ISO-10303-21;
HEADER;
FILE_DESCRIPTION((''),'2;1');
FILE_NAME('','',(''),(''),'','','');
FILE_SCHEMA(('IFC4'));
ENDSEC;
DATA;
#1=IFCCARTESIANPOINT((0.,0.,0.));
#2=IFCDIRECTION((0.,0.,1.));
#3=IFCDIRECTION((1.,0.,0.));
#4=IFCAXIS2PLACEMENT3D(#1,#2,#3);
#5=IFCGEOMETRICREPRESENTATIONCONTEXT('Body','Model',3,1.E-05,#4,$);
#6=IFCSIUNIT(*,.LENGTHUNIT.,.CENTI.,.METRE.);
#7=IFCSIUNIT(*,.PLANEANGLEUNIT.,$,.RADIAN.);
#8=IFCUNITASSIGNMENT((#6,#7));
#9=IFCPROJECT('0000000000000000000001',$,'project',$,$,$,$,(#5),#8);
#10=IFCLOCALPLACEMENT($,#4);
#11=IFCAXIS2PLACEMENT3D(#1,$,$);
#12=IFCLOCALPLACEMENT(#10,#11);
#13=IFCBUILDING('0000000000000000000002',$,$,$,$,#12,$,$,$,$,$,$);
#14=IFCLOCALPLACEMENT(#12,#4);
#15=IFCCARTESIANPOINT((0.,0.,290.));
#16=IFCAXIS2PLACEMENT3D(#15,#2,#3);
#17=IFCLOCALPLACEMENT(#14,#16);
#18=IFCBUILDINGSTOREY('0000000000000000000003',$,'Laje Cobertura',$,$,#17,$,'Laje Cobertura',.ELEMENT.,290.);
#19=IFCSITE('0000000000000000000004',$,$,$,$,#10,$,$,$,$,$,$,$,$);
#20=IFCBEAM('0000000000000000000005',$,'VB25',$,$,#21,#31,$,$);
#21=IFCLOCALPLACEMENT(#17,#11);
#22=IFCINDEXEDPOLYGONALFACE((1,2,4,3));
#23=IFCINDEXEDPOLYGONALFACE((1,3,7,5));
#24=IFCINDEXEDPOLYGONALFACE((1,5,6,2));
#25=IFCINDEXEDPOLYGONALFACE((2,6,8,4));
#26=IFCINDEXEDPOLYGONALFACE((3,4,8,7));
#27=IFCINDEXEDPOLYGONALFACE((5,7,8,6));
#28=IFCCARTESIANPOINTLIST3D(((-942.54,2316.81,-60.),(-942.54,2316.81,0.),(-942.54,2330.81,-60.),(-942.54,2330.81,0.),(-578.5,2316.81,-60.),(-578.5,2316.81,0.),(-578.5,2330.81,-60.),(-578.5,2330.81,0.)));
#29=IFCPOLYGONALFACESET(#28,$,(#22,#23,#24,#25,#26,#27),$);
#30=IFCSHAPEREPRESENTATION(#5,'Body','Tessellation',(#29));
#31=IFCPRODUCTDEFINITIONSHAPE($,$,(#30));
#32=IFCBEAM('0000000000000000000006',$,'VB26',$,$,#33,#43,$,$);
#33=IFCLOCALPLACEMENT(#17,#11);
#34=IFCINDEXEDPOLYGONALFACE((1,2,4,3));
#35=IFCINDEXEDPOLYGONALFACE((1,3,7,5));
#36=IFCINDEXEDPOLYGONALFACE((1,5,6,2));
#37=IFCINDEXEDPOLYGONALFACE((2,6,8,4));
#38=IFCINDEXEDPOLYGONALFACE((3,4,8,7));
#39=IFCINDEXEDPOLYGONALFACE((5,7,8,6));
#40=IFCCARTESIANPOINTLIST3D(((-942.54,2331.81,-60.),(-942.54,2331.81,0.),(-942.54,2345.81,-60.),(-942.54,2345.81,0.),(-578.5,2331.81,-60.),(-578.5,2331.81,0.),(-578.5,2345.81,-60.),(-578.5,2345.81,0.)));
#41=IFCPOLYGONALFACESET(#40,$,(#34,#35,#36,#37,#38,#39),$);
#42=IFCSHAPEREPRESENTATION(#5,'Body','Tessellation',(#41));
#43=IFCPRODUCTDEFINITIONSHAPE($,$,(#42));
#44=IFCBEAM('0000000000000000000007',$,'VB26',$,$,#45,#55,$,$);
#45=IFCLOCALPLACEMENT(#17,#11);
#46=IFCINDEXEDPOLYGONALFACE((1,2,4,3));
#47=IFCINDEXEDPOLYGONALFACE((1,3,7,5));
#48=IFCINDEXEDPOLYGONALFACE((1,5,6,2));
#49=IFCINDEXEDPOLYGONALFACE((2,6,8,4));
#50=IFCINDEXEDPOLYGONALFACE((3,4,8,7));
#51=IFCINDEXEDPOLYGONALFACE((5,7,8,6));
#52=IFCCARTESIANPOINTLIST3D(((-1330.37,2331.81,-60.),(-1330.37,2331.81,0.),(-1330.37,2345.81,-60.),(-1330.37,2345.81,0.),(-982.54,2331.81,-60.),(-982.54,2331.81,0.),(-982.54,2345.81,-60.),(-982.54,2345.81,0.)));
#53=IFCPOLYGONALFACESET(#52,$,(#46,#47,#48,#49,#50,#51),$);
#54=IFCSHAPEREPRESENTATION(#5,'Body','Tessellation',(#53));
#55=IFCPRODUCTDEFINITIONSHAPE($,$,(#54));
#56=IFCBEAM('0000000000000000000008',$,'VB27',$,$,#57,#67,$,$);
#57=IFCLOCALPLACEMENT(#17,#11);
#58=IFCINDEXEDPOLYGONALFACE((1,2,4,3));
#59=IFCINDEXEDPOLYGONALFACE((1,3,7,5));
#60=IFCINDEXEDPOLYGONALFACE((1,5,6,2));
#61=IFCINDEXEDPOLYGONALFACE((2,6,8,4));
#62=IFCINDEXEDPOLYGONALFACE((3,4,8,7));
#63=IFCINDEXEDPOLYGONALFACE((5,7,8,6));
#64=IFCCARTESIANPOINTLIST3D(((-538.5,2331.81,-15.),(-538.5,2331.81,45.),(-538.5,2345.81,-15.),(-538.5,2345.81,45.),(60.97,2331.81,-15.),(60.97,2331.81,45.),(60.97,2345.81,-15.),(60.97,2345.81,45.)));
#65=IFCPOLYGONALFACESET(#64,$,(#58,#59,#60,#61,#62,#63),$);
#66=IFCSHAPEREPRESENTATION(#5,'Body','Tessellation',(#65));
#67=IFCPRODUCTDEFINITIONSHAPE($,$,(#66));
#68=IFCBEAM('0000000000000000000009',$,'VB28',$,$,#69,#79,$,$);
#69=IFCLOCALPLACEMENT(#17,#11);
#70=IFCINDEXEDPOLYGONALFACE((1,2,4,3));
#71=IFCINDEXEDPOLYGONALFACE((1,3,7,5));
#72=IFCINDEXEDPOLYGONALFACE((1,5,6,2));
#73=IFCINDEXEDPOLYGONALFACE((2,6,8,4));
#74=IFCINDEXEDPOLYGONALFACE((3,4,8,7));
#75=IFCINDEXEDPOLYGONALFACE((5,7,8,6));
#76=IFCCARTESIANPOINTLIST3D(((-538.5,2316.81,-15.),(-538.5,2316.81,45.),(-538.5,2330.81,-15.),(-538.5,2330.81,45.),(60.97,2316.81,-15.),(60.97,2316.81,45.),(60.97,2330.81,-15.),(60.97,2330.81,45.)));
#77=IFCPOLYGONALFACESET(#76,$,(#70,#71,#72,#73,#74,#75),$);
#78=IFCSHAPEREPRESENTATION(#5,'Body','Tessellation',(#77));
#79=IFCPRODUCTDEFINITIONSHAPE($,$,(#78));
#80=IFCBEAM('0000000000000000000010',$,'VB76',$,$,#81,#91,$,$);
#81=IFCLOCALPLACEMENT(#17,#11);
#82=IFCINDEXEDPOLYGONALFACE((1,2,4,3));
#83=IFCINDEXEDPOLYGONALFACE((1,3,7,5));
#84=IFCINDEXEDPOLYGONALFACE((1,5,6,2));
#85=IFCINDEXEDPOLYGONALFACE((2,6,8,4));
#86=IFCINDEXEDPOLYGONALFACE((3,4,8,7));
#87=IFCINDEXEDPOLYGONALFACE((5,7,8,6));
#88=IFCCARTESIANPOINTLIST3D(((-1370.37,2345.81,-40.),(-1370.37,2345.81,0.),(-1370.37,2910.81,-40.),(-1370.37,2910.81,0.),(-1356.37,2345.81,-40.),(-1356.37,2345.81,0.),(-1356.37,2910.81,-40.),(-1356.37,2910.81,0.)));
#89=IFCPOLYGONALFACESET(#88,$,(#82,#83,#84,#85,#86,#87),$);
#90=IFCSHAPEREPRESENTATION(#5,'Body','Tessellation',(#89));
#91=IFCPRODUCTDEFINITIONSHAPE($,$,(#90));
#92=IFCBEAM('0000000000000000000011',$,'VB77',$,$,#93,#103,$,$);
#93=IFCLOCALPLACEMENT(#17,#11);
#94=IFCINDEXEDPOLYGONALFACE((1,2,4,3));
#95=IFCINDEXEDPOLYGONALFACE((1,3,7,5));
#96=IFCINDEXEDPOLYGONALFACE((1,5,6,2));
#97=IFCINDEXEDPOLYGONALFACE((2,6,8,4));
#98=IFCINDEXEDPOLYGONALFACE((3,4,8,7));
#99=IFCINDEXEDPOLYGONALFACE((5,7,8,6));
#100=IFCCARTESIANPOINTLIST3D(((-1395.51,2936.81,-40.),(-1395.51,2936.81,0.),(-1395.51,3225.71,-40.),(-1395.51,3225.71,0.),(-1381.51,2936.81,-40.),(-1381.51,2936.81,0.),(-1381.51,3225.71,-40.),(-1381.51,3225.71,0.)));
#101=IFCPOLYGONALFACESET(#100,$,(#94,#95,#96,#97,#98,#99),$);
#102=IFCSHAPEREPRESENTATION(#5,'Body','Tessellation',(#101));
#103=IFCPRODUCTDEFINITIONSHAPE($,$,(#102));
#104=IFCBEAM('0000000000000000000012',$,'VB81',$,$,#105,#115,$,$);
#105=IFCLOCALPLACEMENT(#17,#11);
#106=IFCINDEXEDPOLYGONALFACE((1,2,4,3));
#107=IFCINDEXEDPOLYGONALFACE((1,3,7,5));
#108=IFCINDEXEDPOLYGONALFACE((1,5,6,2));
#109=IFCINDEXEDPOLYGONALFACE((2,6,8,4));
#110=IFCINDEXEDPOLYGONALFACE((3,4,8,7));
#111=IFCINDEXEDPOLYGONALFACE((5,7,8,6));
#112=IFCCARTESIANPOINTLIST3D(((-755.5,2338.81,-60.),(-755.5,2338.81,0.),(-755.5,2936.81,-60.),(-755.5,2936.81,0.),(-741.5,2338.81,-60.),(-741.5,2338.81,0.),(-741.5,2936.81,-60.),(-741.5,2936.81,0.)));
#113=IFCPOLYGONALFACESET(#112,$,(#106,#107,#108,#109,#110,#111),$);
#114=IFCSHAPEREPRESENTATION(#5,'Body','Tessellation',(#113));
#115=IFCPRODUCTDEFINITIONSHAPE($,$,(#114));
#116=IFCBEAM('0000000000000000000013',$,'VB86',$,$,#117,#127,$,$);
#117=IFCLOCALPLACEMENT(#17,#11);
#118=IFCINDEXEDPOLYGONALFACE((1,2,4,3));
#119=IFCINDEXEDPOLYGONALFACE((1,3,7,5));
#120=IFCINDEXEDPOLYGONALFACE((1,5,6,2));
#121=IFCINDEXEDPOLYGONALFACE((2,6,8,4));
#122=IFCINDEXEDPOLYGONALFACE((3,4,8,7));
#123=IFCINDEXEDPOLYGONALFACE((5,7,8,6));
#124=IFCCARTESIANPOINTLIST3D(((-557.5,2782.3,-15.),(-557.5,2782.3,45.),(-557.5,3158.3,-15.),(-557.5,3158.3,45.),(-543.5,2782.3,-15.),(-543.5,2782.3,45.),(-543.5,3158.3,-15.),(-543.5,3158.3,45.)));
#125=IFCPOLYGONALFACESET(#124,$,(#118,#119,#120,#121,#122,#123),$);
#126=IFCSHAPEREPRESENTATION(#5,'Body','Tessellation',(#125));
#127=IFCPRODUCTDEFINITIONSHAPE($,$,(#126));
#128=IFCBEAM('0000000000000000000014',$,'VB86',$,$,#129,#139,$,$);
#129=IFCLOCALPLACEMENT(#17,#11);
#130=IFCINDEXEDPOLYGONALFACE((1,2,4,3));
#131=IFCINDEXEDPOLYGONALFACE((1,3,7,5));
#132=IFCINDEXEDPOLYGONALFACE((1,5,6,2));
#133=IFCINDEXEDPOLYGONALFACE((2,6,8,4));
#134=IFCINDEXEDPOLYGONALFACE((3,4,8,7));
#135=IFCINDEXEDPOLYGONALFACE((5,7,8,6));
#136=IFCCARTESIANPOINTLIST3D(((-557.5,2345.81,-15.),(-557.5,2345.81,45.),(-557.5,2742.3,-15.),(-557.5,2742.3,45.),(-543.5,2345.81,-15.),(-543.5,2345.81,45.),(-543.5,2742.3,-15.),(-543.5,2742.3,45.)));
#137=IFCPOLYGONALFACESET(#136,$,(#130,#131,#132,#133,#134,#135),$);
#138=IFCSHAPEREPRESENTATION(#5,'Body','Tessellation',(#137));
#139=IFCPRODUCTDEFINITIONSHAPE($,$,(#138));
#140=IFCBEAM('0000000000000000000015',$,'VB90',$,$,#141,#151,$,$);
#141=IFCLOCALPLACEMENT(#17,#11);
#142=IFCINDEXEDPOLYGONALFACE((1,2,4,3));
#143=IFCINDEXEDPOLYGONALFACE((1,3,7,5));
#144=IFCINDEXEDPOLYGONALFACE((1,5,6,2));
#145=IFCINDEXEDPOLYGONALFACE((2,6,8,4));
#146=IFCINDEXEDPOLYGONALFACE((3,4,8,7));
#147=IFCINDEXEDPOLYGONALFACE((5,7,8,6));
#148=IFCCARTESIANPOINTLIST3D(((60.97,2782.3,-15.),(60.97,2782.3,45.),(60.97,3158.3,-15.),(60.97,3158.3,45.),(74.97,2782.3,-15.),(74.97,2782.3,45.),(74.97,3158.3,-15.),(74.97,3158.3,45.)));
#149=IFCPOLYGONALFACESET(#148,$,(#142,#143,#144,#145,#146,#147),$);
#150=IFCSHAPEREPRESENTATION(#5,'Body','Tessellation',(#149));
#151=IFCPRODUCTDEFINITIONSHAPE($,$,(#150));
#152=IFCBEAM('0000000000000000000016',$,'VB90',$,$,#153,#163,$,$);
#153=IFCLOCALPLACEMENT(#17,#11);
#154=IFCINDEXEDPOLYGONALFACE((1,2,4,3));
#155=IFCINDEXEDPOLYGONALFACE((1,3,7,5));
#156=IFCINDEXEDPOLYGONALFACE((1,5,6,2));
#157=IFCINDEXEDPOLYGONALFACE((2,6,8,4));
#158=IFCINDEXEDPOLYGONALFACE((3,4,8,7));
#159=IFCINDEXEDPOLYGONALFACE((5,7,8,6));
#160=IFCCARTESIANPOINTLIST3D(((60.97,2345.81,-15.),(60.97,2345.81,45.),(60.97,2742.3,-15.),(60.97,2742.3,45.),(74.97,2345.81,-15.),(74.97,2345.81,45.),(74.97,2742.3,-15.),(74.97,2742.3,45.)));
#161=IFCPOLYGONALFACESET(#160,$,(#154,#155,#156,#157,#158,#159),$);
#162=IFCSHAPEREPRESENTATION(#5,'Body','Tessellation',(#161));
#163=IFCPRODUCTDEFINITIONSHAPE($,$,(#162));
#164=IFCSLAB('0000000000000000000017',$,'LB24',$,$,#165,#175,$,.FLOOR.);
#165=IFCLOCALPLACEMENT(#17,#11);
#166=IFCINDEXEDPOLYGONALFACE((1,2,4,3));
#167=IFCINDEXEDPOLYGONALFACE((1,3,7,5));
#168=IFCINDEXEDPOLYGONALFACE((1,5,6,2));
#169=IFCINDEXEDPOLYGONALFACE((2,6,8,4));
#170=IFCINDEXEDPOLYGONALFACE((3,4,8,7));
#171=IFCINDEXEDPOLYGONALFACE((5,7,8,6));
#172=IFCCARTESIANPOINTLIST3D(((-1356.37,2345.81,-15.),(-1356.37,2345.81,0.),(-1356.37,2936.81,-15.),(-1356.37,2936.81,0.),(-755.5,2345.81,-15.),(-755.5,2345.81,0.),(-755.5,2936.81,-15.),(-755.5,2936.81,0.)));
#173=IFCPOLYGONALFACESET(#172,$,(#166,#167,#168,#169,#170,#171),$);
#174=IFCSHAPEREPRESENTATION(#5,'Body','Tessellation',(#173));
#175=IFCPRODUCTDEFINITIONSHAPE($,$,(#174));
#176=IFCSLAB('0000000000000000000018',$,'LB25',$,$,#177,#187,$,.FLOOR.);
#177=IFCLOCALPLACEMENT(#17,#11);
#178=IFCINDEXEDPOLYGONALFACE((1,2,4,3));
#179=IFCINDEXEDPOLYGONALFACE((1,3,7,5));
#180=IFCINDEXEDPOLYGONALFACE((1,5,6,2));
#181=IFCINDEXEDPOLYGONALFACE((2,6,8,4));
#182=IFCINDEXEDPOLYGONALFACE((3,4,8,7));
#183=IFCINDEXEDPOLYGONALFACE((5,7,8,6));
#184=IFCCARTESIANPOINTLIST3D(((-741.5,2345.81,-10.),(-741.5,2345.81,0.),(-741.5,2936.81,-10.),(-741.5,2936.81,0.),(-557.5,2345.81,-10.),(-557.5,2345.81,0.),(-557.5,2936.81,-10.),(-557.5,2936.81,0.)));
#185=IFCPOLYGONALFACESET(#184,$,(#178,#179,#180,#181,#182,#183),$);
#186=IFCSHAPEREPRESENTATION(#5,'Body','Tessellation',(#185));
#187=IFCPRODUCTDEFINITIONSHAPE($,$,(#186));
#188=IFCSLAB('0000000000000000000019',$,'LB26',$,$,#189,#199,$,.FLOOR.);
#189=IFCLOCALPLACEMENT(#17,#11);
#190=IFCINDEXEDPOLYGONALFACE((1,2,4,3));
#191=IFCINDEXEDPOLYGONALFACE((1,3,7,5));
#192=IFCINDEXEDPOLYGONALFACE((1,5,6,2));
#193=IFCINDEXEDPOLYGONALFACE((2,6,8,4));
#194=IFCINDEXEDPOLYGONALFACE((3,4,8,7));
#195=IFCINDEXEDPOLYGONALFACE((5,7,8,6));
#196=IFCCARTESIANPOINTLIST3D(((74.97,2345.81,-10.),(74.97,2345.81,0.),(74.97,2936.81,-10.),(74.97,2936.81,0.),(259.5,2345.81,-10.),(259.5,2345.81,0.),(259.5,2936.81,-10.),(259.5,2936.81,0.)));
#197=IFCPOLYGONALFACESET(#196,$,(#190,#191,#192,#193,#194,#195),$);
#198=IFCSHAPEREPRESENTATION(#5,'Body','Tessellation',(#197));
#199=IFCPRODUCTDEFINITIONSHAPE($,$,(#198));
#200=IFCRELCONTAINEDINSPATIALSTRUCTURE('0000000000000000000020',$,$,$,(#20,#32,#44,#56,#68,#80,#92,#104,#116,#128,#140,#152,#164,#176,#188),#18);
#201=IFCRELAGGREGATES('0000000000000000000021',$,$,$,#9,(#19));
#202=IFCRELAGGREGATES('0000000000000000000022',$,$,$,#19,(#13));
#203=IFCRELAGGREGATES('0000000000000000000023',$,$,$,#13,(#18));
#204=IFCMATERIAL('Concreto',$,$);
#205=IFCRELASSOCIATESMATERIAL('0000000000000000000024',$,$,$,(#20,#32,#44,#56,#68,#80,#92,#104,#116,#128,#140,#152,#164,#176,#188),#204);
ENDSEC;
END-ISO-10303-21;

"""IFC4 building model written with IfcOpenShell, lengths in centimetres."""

from ifc_helpers import new_model, si_unit, frame, origin, origin_with_axes, origin_2d_with_axis, place, context, project, spatial, polyline, rectangle, outline, extrude, material, element, save


model = new_model("IFC4")

# Units and contexts
model_context = context("Model", 3, precision=1e-05, world=origin_with_axes(), identifier="Body")
ifc_project = project(units=[si_unit("LENGTHUNIT", "METRE", prefix="CENTI"), si_unit("PLANEANGLEUNIT", "RADIAN")], contexts=[model_context])

# Site, building, storey
site_placement = place(None, origin_with_axes())
site = spatial("IfcSite", under=ifc_project, at=site_placement)
building_placement = place(site_placement, origin())
building = spatial("IfcBuilding", under=site, at=building_placement)
placement = place(building_placement, origin_with_axes())
storey_placement = place(placement, frame((0.0, 0.0, 290.0), z_axis=(0.0, 0.0, 1.0), x_axis=(1.0, 0.0, 0.0)))
storey = spatial("IfcBuildingStorey", under=building, at=storey_placement, Name="Laje Cobertura", LongName="Laje Cobertura", CompositionType="ELEMENT", Elevation=290.0)

# Shared definitions
ifc_material = material(Name="Concreto")

# Beams
for number, where, z_axis, x_axis, name in (
    (1, (-760.52, 2323.81, 0.0), (0.0, 0.0, 1.0), (1.0, 0.0, 0.0), "VB25"),
    (2, (-760.52, 2338.81, 0.0), (0.0, 0.0, 1.0), (1.0, 0.0, 0.0), "VB26"),
):
    element("IfcBeam", number, at=place(storey_placement, frame(where, z_axis=z_axis, x_axis=x_axis)), inside=storey, material=ifc_material, Name=name, context=model_context, shape_type="SolidModel", body=[
        extrude(rectangle(XDim=14.0, YDim=60.0, at=origin_2d_with_axis()), frame((-182.02, 0.0, -30.0), z_axis=(1.0, 0.0, 0.0), x_axis=(0.0, 1.0, 0.0)), (0.0, 0.0, 1.0), 364.04),
    ])
beam_1_placement = place(storey_placement, frame((-1156.45, 2338.81, 0.0), z_axis=(0.0, 0.0, 1.0), x_axis=(1.0, 0.0, 0.0)))
element("IfcBeam", 3, at=beam_1_placement, inside=storey, material=ifc_material, Name="VB26", context=model_context, shape_type="SolidModel", body=[
    extrude(rectangle(XDim=14.0, YDim=60.0, at=origin_2d_with_axis()), frame((-173.91, 0.0, -30.0), z_axis=(1.0, 0.0, 0.0), x_axis=(0.0, 1.0, 0.0)), (0.0, 0.0, 1.0), 347.83),
])
for number, where, z_axis, x_axis, name in (
    (4, (-238.76, 2338.81, 45.0), (0.0, 0.0, 1.0), (1.0, 0.0, 0.0), "VB27"),
    (5, (-238.76, 2323.81, 45.0), (0.0, 0.0, 1.0), (1.0, 0.0, 0.0), "VB28"),
):
    element("IfcBeam", number, at=place(storey_placement, frame(where, z_axis=z_axis, x_axis=x_axis)), inside=storey, material=ifc_material, Name=name, context=model_context, shape_type="SolidModel", body=[
        extrude(rectangle(XDim=14.0, YDim=60.0, at=origin_2d_with_axis()), frame((-299.74, 0.0, -30.0), z_axis=(1.0, 0.0, 0.0), x_axis=(0.0, 1.0, 0.0)), (0.0, 0.0, 1.0), 599.47),
    ])
beam_2_placement = place(storey_placement, frame((-1363.37, 2628.31, 0.0), z_axis=(0.0, 0.0, 1.0), x_axis=(1.0, 0.0, 0.0)))
element("IfcBeam", 6, at=beam_2_placement, inside=storey, material=ifc_material, Name="VB76", context=model_context, shape_type="SolidModel", body=[
    extrude(rectangle(XDim=14.0, YDim=40.0, at=origin_2d_with_axis()), frame((0.0, -282.5, -20.0), z_axis=(0.0, 1.0, 0.0), x_axis=(-1.0, 0.0, 0.0)), (0.0, 0.0, 1.0), 565.0),
])
beam_3_placement = place(storey_placement, frame((-1388.51, 3081.26, 0.0), z_axis=(0.0, 0.0, 1.0), x_axis=(1.0, 0.0, 0.0)))
element("IfcBeam", 7, at=beam_3_placement, inside=storey, material=ifc_material, Name="VB77", context=model_context, shape_type="SolidModel", body=[
    extrude(rectangle(XDim=14.0, YDim=40.0, at=origin_2d_with_axis()), frame((0.0, -144.45, -20.0), z_axis=(0.0, 1.0, 0.0), x_axis=(-1.0, 0.0, 0.0)), (0.0, 0.0, 1.0), 288.9),
])
beam_4_placement = place(storey_placement, frame((-748.5, 2637.81, 0.0), z_axis=(0.0, 0.0, 1.0), x_axis=(1.0, 0.0, 0.0)))
element("IfcBeam", 8, at=beam_4_placement, inside=storey, material=ifc_material, Name="VB81", context=model_context, shape_type="SolidModel", body=[
    extrude(rectangle(XDim=14.0, YDim=60.0, at=origin_2d_with_axis()), frame((0.0, -299.0, -30.0), z_axis=(0.0, 1.0, 0.0), x_axis=(-1.0, 0.0, 0.0)), (0.0, 0.0, 1.0), 598.0),
])
beam_5_placement = place(storey_placement, frame((-550.5, 2970.3, 45.0), z_axis=(0.0, 0.0, 1.0), x_axis=(1.0, 0.0, 0.0)))
element("IfcBeam", 9, at=beam_5_placement, inside=storey, material=ifc_material, Name="VB86", context=model_context, shape_type="SolidModel", body=[
    extrude(rectangle(XDim=14.0, YDim=60.0, at=origin_2d_with_axis()), frame((0.0, -188.0, -30.0), z_axis=(0.0, 1.0, 0.0), x_axis=(-1.0, 0.0, 0.0)), (0.0, 0.0, 1.0), 376.0),
])
beam_6_placement = place(storey_placement, frame((-550.5, 2544.05, 45.0), z_axis=(0.0, 0.0, 1.0), x_axis=(1.0, 0.0, 0.0)))
element("IfcBeam", 10, at=beam_6_placement, inside=storey, material=ifc_material, Name="VB86", context=model_context, shape_type="SolidModel", body=[
    extrude(rectangle(XDim=14.0, YDim=60.0, at=origin_2d_with_axis()), frame((0.0, -198.25, -30.0), z_axis=(0.0, 1.0, 0.0), x_axis=(-1.0, 0.0, 0.0)), (0.0, 0.0, 1.0), 396.49),
])
beam_7_placement = place(storey_placement, frame((67.97, 2970.3, 45.0), z_axis=(0.0, 0.0, 1.0), x_axis=(1.0, 0.0, 0.0)))
element("IfcBeam", 11, at=beam_7_placement, inside=storey, material=ifc_material, Name="VB90", context=model_context, shape_type="SolidModel", body=[
    extrude(rectangle(XDim=14.0, YDim=60.0, at=origin_2d_with_axis()), frame((0.0, -188.0, -30.0), z_axis=(0.0, 1.0, 0.0), x_axis=(-1.0, 0.0, 0.0)), (0.0, 0.0, 1.0), 376.0),
])
beam_8_placement = place(storey_placement, frame((67.97, 2544.05, 45.0), z_axis=(0.0, 0.0, 1.0), x_axis=(1.0, 0.0, 0.0)))
element("IfcBeam", 12, at=beam_8_placement, inside=storey, material=ifc_material, Name="VB90", context=model_context, shape_type="SolidModel", body=[
    extrude(rectangle(XDim=14.0, YDim=60.0, at=origin_2d_with_axis()), frame((0.0, -198.25, -30.0), z_axis=(0.0, 1.0, 0.0), x_axis=(-1.0, 0.0, 0.0)), (0.0, 0.0, 1.0), 396.49),
])

# Slabs
slab_1_placement = place(storey_placement, frame((-1055.93, 2641.31, 0.0), z_axis=(0.0, 0.0, 1.0), x_axis=(1.0, 0.0, 0.0)))
element("IfcSlab", 13, at=slab_1_placement, inside=storey, material=ifc_material, Name="LB24", PredefinedType="FLOOR", context=model_context, shape_type="SolidModel", body=[
    extrude(outline(polyline([(300.44, -295.5), (300.44, 295.5), (-300.44, 295.5), (-300.43, -295.5), (300.44, -295.5), (300.44, -295.5)])), frame((0.0, 0.0, -15.0), z_axis=(0.0, 0.0, 1.0), x_axis=(1.0, 0.0, 0.0)), (0.0, 0.0, 1.0), 15.0),
])
slab_2_placement = place(storey_placement, frame((-649.5, 2641.31, 0.0), z_axis=(0.0, 0.0, 1.0), x_axis=(1.0, 0.0, 0.0)))
element("IfcSlab", 14, at=slab_2_placement, inside=storey, material=ifc_material, Name="LB25", PredefinedType="FLOOR", context=model_context, shape_type="SolidModel", body=[
    extrude(outline(polyline([(92.0, -295.5), (92.0, 295.5), (-92.0, 295.5), (-92.0, -295.5), (92.0, -295.5), (92.0, -295.5)])), frame((0.0, 0.0, -10.0), z_axis=(0.0, 0.0, 1.0), x_axis=(1.0, 0.0, 0.0)), (0.0, 0.0, 1.0), 10.0),
])
slab_3_placement = place(storey_placement, frame((167.24, 2641.31, 0.0), z_axis=(0.0, 0.0, 1.0), x_axis=(1.0, 0.0, 0.0)))
element("IfcSlab", 15, at=slab_3_placement, inside=storey, material=ifc_material, Name="LB26", PredefinedType="FLOOR", context=model_context, shape_type="SolidModel", body=[
    extrude(outline(polyline([(92.27, 295.5), (-92.26, 295.5), (-92.27, -295.5), (92.27, -295.5), (92.27, 295.5), (92.27, 295.5)])), frame((0.0, 0.0, -10.0), z_axis=(0.0, 0.0, 1.0), x_axis=(1.0, 0.0, 0.0)), (0.0, 0.0, 1.0), 10.0),
])

save(model, "model.ifc")
